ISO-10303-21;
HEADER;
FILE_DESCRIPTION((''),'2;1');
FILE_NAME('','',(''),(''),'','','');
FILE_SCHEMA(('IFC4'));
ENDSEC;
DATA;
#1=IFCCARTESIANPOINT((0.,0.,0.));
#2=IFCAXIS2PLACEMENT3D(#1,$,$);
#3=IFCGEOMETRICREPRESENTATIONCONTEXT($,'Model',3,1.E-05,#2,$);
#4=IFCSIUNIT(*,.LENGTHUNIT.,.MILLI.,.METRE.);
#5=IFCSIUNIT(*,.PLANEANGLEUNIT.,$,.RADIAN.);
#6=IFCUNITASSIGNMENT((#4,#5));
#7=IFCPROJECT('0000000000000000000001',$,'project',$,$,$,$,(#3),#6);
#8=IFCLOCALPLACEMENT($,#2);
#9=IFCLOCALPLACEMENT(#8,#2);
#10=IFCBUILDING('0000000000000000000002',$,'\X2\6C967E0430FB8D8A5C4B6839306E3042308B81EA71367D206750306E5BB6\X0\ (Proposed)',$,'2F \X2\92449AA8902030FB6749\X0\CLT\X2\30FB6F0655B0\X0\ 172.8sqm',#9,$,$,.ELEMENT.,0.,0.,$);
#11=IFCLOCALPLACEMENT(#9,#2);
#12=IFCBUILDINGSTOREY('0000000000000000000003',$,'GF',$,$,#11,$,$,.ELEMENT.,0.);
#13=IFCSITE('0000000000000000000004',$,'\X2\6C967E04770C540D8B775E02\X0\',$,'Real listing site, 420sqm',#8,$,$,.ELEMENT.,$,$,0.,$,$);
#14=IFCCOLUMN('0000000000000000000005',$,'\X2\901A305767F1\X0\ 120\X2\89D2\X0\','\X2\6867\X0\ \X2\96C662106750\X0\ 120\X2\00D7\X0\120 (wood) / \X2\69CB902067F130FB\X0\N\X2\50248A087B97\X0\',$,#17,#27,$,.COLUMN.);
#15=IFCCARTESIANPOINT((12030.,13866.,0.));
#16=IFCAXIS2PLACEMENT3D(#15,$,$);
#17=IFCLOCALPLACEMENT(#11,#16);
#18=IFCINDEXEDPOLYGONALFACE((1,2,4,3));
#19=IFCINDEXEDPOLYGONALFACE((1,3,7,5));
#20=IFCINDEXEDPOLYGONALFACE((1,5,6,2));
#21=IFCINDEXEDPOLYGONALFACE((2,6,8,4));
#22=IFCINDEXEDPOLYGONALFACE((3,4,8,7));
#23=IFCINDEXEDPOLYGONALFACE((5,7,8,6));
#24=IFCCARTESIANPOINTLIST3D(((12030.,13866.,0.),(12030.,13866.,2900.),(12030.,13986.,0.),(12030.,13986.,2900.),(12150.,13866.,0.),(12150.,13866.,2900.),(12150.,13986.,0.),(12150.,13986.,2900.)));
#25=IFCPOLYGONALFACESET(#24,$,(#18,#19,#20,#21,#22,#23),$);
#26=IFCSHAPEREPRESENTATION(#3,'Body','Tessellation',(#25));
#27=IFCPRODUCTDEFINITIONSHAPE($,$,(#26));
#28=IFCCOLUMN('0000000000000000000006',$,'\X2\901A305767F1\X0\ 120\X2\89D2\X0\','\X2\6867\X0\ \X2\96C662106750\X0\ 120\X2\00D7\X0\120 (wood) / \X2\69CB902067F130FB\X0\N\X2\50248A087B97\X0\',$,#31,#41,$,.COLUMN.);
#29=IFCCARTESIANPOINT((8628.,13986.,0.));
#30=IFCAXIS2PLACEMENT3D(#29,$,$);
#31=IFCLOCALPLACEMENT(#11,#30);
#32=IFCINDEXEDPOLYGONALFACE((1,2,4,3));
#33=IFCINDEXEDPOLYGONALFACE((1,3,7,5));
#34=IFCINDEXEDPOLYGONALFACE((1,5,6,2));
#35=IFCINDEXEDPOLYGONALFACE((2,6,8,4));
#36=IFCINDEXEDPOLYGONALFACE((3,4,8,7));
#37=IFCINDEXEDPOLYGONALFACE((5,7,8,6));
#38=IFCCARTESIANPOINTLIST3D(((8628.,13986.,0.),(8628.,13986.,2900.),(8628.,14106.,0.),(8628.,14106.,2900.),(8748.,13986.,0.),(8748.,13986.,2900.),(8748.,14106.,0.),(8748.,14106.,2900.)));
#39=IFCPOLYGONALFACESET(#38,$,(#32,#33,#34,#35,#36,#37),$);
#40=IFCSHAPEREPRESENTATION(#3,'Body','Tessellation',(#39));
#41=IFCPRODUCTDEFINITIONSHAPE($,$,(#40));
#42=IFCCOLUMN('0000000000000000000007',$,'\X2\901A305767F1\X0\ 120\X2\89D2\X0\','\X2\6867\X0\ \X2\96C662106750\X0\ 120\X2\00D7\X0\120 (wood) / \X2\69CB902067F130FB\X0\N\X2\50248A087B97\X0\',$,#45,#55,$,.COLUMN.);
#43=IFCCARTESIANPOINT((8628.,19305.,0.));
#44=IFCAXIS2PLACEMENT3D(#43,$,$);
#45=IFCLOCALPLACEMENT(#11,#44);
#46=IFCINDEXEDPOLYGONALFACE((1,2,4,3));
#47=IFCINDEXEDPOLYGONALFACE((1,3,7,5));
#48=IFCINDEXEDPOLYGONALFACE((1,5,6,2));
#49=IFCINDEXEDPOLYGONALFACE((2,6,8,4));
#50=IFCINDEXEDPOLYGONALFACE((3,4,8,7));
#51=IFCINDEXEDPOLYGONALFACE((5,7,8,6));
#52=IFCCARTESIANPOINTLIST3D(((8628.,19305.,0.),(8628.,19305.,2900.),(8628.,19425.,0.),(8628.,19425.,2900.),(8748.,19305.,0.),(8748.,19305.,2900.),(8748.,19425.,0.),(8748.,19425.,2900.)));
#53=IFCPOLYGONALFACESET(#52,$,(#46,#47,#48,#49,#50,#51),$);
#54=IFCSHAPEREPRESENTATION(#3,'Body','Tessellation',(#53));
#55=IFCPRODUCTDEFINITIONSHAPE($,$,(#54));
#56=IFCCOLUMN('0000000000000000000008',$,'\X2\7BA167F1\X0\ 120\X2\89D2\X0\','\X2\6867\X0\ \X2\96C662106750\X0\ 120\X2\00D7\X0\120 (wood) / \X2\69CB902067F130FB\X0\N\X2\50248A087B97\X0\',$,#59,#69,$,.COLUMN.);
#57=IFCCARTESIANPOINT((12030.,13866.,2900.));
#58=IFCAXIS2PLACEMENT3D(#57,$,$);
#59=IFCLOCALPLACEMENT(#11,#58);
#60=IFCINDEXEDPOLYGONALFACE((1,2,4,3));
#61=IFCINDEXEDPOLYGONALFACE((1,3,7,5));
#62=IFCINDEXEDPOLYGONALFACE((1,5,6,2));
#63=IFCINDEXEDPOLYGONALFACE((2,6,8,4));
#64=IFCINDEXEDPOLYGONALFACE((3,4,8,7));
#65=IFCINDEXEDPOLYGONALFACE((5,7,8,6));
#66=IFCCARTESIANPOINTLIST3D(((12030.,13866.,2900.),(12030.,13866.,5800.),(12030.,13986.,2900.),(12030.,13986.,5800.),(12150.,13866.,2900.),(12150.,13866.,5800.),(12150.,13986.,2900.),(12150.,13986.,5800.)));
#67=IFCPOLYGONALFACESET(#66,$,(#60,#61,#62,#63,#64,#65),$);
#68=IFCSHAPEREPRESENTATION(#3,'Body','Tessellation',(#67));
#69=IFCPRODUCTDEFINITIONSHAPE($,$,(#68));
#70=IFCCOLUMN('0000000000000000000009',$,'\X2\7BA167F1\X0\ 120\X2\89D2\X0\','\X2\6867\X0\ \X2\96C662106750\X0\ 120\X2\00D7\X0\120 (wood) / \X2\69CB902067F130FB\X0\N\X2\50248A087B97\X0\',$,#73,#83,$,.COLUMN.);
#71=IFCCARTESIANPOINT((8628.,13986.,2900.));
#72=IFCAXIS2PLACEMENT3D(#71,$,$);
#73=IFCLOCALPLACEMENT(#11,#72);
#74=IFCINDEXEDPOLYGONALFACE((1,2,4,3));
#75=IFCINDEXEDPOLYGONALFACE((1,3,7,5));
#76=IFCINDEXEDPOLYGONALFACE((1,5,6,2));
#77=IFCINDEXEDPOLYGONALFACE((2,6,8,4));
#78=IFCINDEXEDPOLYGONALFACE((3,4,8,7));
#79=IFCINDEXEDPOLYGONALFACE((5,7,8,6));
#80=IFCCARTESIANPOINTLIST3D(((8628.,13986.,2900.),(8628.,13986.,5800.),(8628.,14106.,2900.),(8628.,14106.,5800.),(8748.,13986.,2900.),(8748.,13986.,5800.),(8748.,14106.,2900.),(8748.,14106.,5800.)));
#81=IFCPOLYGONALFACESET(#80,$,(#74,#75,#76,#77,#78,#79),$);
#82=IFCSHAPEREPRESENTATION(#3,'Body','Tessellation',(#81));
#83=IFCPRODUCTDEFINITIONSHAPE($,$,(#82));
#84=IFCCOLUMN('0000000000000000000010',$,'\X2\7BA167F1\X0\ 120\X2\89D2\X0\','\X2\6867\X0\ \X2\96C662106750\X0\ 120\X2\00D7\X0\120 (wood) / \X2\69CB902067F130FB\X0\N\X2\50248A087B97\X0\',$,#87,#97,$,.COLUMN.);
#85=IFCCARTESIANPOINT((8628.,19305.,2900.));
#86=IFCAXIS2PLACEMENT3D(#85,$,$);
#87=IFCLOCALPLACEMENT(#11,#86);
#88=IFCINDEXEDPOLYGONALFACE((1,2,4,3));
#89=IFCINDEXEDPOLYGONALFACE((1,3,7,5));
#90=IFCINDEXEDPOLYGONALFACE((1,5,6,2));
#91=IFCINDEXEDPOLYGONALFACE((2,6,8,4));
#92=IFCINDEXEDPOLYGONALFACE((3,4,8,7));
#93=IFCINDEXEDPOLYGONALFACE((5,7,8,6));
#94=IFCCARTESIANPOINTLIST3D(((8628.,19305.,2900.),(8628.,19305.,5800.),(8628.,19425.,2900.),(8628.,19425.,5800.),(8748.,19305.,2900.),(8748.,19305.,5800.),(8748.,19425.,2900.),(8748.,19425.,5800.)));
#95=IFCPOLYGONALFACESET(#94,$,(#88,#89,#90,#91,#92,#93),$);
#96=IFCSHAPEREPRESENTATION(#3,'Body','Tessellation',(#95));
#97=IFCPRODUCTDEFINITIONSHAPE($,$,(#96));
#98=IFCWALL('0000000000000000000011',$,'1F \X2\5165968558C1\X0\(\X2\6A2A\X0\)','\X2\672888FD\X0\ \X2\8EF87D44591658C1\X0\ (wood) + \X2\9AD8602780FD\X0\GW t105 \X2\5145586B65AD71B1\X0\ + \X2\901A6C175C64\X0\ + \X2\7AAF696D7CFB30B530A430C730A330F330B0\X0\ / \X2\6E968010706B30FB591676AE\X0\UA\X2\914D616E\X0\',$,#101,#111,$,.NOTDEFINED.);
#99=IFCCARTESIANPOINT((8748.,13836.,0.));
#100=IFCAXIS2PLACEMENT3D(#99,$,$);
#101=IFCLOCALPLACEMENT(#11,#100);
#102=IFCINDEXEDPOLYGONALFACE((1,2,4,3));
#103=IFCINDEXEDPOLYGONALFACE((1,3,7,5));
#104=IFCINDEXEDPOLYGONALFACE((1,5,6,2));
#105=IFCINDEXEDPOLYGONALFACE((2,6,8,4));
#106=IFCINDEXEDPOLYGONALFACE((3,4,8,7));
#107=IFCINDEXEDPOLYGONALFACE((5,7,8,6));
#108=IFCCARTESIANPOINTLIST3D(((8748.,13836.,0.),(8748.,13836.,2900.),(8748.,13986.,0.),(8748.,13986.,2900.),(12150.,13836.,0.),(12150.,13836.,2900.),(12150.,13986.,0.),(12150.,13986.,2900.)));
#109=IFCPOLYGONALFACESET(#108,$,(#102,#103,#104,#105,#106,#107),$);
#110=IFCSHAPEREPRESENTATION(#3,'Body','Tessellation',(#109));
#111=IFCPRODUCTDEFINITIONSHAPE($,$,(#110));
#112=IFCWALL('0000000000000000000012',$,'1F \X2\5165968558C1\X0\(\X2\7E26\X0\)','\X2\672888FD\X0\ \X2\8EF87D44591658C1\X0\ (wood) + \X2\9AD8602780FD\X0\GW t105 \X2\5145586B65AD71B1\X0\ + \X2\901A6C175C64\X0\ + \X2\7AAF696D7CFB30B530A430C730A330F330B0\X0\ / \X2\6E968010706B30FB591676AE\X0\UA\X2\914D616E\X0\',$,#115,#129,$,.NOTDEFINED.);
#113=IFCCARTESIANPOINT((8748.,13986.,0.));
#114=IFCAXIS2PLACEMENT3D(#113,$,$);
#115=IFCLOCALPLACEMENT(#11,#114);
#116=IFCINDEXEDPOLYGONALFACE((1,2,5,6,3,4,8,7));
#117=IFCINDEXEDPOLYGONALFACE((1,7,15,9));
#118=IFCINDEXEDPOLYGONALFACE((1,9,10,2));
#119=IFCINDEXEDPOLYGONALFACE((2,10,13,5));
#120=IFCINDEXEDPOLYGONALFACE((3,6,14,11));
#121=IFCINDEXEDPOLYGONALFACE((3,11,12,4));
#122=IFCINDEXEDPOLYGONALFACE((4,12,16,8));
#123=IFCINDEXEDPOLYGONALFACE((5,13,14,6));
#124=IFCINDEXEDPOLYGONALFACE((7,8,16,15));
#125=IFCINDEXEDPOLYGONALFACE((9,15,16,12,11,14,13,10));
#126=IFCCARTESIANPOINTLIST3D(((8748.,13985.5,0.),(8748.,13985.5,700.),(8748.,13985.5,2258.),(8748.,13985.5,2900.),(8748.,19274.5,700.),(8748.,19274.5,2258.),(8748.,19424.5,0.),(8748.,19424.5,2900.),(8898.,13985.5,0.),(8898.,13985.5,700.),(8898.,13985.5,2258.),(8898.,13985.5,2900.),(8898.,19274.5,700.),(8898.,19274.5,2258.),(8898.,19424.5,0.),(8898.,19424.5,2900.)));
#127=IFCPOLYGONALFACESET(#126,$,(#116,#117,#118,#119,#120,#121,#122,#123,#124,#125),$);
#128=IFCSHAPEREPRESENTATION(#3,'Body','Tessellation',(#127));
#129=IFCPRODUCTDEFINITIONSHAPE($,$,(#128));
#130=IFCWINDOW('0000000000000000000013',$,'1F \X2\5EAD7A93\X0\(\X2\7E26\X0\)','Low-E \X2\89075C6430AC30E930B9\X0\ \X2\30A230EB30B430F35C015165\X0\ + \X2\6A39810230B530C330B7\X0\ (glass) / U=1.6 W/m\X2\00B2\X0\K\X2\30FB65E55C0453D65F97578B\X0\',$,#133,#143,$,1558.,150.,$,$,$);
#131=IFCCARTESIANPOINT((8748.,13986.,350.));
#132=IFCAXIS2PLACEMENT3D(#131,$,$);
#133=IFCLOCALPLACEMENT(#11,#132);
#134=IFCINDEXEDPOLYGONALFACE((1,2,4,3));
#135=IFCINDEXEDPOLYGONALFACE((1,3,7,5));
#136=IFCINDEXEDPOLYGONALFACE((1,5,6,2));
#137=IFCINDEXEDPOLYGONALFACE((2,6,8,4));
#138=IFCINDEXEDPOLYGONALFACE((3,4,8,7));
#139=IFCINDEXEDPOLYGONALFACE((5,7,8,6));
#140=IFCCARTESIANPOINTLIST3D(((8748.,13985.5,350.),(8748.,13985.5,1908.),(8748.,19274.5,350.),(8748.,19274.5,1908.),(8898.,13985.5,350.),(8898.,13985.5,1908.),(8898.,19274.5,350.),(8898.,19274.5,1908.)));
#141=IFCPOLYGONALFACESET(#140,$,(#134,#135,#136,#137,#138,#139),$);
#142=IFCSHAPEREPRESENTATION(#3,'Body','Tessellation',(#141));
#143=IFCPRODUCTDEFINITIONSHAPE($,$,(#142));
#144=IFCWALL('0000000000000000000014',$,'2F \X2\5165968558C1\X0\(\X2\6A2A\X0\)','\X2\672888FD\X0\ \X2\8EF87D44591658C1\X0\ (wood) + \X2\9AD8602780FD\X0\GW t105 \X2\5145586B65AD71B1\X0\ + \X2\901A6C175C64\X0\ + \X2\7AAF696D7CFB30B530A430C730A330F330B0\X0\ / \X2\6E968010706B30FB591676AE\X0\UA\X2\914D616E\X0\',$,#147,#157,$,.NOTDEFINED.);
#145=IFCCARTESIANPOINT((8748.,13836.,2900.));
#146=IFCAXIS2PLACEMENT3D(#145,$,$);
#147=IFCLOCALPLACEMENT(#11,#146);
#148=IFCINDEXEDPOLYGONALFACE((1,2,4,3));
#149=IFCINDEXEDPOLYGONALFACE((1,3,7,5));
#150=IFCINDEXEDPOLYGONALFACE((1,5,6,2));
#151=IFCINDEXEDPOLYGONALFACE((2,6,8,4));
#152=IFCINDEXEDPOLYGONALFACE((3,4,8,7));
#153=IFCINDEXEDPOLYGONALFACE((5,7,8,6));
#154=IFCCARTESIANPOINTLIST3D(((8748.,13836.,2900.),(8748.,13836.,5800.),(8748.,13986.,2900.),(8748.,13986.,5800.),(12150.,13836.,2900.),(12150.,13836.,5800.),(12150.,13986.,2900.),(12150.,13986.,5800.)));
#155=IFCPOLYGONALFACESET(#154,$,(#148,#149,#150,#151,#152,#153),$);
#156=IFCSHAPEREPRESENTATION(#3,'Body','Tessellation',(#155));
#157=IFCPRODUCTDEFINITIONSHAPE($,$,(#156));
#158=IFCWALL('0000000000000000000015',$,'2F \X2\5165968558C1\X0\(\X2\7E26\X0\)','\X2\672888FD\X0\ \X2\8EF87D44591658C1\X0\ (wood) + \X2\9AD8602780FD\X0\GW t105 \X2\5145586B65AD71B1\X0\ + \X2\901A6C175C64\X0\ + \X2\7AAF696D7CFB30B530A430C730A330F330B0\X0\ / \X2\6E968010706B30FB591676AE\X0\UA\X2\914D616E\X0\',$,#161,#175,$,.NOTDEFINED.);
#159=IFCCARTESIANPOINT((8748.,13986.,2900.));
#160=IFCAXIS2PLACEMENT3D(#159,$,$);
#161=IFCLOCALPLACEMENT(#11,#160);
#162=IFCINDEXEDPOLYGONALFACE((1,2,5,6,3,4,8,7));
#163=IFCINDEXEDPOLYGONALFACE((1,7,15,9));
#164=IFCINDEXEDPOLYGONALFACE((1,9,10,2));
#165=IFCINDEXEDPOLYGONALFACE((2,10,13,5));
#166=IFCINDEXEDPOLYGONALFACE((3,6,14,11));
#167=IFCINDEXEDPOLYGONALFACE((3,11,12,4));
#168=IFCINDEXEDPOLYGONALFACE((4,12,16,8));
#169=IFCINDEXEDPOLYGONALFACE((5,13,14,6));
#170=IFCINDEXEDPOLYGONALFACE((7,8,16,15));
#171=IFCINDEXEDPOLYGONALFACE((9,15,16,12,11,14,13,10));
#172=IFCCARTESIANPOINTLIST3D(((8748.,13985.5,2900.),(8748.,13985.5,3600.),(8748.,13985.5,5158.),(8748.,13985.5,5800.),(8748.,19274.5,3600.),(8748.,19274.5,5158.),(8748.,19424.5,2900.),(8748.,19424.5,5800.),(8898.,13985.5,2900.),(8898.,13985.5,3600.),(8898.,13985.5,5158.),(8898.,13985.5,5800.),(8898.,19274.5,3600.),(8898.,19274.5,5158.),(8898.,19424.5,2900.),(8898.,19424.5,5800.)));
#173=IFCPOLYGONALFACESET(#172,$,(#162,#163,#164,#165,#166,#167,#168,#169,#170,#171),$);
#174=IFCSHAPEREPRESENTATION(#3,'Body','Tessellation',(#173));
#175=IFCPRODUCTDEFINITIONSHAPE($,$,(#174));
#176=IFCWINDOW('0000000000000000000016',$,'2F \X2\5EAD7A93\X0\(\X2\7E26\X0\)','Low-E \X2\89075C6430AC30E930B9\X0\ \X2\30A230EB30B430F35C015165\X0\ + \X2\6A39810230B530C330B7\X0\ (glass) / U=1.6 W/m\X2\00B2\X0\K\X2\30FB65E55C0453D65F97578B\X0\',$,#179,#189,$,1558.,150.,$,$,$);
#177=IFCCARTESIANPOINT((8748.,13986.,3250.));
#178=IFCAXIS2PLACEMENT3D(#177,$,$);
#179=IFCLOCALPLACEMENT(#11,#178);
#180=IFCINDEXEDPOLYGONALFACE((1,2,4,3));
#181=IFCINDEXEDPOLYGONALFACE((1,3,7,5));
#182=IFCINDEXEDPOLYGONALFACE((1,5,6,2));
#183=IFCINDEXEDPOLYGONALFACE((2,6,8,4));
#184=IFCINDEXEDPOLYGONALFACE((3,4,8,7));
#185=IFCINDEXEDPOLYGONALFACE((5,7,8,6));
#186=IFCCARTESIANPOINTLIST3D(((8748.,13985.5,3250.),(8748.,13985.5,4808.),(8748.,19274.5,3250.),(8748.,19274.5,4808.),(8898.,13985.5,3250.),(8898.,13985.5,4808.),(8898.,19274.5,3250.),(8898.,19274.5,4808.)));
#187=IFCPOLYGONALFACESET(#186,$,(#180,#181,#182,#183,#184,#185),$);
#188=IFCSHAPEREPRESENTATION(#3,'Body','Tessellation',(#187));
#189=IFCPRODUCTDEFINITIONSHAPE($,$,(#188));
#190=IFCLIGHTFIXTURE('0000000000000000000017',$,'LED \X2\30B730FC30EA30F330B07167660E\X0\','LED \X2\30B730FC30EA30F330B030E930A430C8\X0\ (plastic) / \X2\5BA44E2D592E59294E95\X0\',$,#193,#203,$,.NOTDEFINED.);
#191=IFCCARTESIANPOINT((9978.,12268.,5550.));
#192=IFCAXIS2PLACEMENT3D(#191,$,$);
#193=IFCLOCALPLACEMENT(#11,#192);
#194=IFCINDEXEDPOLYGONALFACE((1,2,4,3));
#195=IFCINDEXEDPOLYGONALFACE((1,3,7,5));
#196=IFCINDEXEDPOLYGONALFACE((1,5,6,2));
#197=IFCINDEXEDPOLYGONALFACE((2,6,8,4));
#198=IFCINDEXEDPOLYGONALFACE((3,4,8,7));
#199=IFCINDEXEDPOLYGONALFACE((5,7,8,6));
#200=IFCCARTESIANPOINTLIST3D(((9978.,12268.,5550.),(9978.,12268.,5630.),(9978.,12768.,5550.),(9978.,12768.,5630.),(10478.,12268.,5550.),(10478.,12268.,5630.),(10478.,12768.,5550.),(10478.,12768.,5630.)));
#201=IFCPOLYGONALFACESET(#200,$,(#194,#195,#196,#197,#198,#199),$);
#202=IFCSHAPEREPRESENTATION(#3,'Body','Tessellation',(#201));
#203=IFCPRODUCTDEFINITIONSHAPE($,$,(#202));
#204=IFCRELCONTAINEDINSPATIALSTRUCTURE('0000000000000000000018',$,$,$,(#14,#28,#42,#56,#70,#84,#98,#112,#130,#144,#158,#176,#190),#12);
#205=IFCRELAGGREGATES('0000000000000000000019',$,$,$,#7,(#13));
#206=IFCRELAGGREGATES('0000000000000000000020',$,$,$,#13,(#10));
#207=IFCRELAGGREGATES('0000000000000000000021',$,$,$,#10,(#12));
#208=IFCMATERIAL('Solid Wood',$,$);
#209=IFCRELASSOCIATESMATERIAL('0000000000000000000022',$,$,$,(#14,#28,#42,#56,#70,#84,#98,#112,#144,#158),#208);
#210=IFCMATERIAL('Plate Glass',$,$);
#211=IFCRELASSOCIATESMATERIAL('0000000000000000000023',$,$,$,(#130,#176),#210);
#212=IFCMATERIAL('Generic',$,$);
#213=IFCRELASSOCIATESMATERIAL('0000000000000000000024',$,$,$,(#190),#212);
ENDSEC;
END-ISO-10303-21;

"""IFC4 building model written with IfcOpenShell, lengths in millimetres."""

from ifc_helpers import new_model, si_unit, frame, frame_2d, origin, place, context, project, spatial, rectangle, extrude, material, element, fill, save


model = new_model("IFC4")

# Units and contexts
model_context = context("Model", 3, precision=1e-05, world=origin())
ifc_project = project(units=[si_unit("LENGTHUNIT", "METRE", prefix="MILLI"), si_unit("PLANEANGLEUNIT", "RADIAN")], contexts=[model_context])

# Site, building, storey
site_placement = place(None, origin())
site = spatial("IfcSite", under=ifc_project, at=site_placement, Name="沖縄県名護市", ObjectType="Real listing site, 420sqm", CompositionType="ELEMENT", RefElevation=0.0)
building_placement = place(site_placement, origin())
building = spatial("IfcBuilding", under=site, at=building_placement, Name="沖縄・越屋根のある自然素材の家 (Proposed)", ObjectType="2F 鉄骨造・杉CLT・漆喰 172.8sqm", CompositionType="ELEMENT", ElevationOfRefHeight=0.0, ElevationOfTerrain=0.0)
storey_placement = place(building_placement, origin())
storey = spatial("IfcBuildingStorey", under=building, at=storey_placement, Name="GF", CompositionType="ELEMENT", Elevation=0.0)

# Columns
ifc_material_1 = material(Name="Solid Wood")
column_1_placement = place(storey_placement, frame((12030.0, 13866.0, 0.0)))
element("IfcColumn", 1, at=column_1_placement, inside=storey, material=ifc_material_1, Name="通し柱 120角", Description="桧 集成材 120×120 (wood) / 構造柱・N値計算", PredefinedType="COLUMN", context=model_context, shape_type="SweptSolid", body=[
    extrude(rectangle(XDim=120.0, YDim=120.0, at=frame_2d((60.0, 60.0))), frame((12030.0, 13866.0, 0.0)), (0.0, 0.0, 1.0), 2900.0),
])
column_2_placement = place(storey_placement, frame((8628.0, 13986.0, 0.0)))
element("IfcColumn", 2, at=column_2_placement, inside=storey, material=ifc_material_1, Name="通し柱 120角", Description="桧 集成材 120×120 (wood) / 構造柱・N値計算", PredefinedType="COLUMN", context=model_context, shape_type="SweptSolid", body=[
    extrude(rectangle(XDim=120.0, YDim=120.0, at=frame_2d((60.0, 60.0))), frame((8628.0, 13986.0, 0.0)), (0.0, 0.0, 1.0), 2900.0),
])
column_3_placement = place(storey_placement, frame((8628.0, 19305.0, 0.0)))
element("IfcColumn", 3, at=column_3_placement, inside=storey, material=ifc_material_1, Name="通し柱 120角", Description="桧 集成材 120×120 (wood) / 構造柱・N値計算", PredefinedType="COLUMN", context=model_context, shape_type="SweptSolid", body=[
    extrude(rectangle(XDim=120.0, YDim=120.0, at=frame_2d((60.0, 60.0))), frame((8628.0, 19305.0, 0.0)), (0.0, 0.0, 1.0), 2900.0),
])
column_4_placement = place(storey_placement, frame((12030.0, 13866.0, 2900.0)))
element("IfcColumn", 4, at=column_4_placement, inside=storey, material=ifc_material_1, Name="管柱 120角", Description="桧 集成材 120×120 (wood) / 構造柱・N値計算", PredefinedType="COLUMN", context=model_context, shape_type="SweptSolid", body=[
    extrude(rectangle(XDim=120.0, YDim=120.0, at=frame_2d((60.0, 60.0))), frame((12030.0, 13866.0, 2900.0)), (0.0, 0.0, 1.0), 2900.0),
])
column_5_placement = place(storey_placement, frame((8628.0, 13986.0, 2900.0)))
element("IfcColumn", 5, at=column_5_placement, inside=storey, material=ifc_material_1, Name="管柱 120角", Description="桧 集成材 120×120 (wood) / 構造柱・N値計算", PredefinedType="COLUMN", context=model_context, shape_type="SweptSolid", body=[
    extrude(rectangle(XDim=120.0, YDim=120.0, at=frame_2d((60.0, 60.0))), frame((8628.0, 13986.0, 2900.0)), (0.0, 0.0, 1.0), 2900.0),
])
column_6_placement = place(storey_placement, frame((8628.0, 19305.0, 2900.0)))
element("IfcColumn", 6, at=column_6_placement, inside=storey, material=ifc_material_1, Name="管柱 120角", Description="桧 集成材 120×120 (wood) / 構造柱・N値計算", PredefinedType="COLUMN", context=model_context, shape_type="SweptSolid", body=[
    extrude(rectangle(XDim=120.0, YDim=120.0, at=frame_2d((60.0, 60.0))), frame((8628.0, 19305.0, 2900.0)), (0.0, 0.0, 1.0), 2900.0),
])

# Wall
wall_1_placement = place(storey_placement, frame((8748.0, 13836.0, 0.0)))
element("IfcWall", 7, at=wall_1_placement, inside=storey, material=ifc_material_1, Name="1F 入隅壁(横)", Description="木製 軸組外壁 (wood) + 高性能GW t105 充填断熱 + 通気層 + 窯業系サイディング / 準耐火・外皮UA配慮", PredefinedType="NOTDEFINED", context=model_context, shape_type="SweptSolid", body=[
    extrude(rectangle(XDim=3402.0, YDim=150.0, at=frame_2d((1701.0, 75.0))), frame((8748.0, 13836.0, 0.0)), (0.0, 0.0, 1.0), 2900.0),
])

# Wall, opening, window
wall_2_placement = place(storey_placement, frame((8748.0, 13986.0, 0.0)))
wall_2 = element("IfcWall", 8, at=wall_2_placement, inside=storey, material=ifc_material_1, Name="1F 入隅壁(縦)", Description="木製 軸組外壁 (wood) + 高性能GW t105 充填断熱 + 通気層 + 窯業系サイディング / 準耐火・外皮UA配慮", PredefinedType="NOTDEFINED", context=model_context, shape_type="SweptSolid", body=[
    extrude(rectangle(XDim=150.0, YDim=5439.0, at=frame_2d((75.0, 2719.0))), frame((8748.0, 13986.0, 0.0)), (0.0, 0.0, 1.0), 2900.0),
])
opening_1_placement = place(storey_placement, frame((8748.0, 13986.0, 350.0)))
opening_1 = element("IfcOpeningElement", 9, at=opening_1_placement, cuts=wall_2, PredefinedType="NOTDEFINED", context=model_context, shape_type="SweptSolid", body=[
    extrude(rectangle(XDim=150.0, YDim=5289.0, at=frame_2d((75.0, 2644.0))), frame((8748.0, 13986.0, 350.0)), (0.0, 0.0, 1.0), 1558.0),
])
ifc_material_2 = material(Name="Plate Glass")
window_1_placement = place(storey_placement, frame((8748.0, 13986.0, 350.0)))
window_1 = element("IfcWindow", 10, at=window_1_placement, inside=storey, material=ifc_material_2, Name="1F 庭窓(縦)", Description="Low-E 複層ガラス アルゴン封入 + 樹脂サッシ (glass) / U=1.6 W/m²K・日射取得型", OverallHeight=1558.0, OverallWidth=150.0, context=model_context, shape_type="SweptSolid", body=[
    extrude(rectangle(XDim=150.0, YDim=5289.0, at=frame_2d((75.0, 2644.0))), frame((8748.0, 13986.0, 350.0)), (0.0, 0.0, 1.0), 1558.0),
])
fill(opening_1, window_1)

# Wall
wall_3_placement = place(storey_placement, frame((8748.0, 13836.0, 2900.0)))
element("IfcWall", 11, at=wall_3_placement, inside=storey, material=ifc_material_1, Name="2F 入隅壁(横)", Description="木製 軸組外壁 (wood) + 高性能GW t105 充填断熱 + 通気層 + 窯業系サイディング / 準耐火・外皮UA配慮", PredefinedType="NOTDEFINED", context=model_context, shape_type="SweptSolid", body=[
    extrude(rectangle(XDim=3402.0, YDim=150.0, at=frame_2d((1701.0, 75.0))), frame((8748.0, 13836.0, 2900.0)), (0.0, 0.0, 1.0), 2900.0),
])

# Wall, opening, window
wall_4_placement = place(storey_placement, frame((8748.0, 13986.0, 2900.0)))
wall_4 = element("IfcWall", 12, at=wall_4_placement, inside=storey, material=ifc_material_1, Name="2F 入隅壁(縦)", Description="木製 軸組外壁 (wood) + 高性能GW t105 充填断熱 + 通気層 + 窯業系サイディング / 準耐火・外皮UA配慮", PredefinedType="NOTDEFINED", context=model_context, shape_type="SweptSolid", body=[
    extrude(rectangle(XDim=150.0, YDim=5439.0, at=frame_2d((75.0, 2719.0))), frame((8748.0, 13986.0, 2900.0)), (0.0, 0.0, 1.0), 2900.0),
])
opening_2_placement = place(storey_placement, frame((8748.0, 13986.0, 3250.0)))
opening_2 = element("IfcOpeningElement", 13, at=opening_2_placement, cuts=wall_4, PredefinedType="NOTDEFINED", context=model_context, shape_type="SweptSolid", body=[
    extrude(rectangle(XDim=150.0, YDim=5289.0, at=frame_2d((75.0, 2644.0))), frame((8748.0, 13986.0, 3250.0)), (0.0, 0.0, 1.0), 1558.0),
])
window_2_placement = place(storey_placement, frame((8748.0, 13986.0, 3250.0)))
window_2 = element("IfcWindow", 14, at=window_2_placement, inside=storey, material=ifc_material_2, Name="2F 庭窓(縦)", Description="Low-E 複層ガラス アルゴン封入 + 樹脂サッシ (glass) / U=1.6 W/m²K・日射取得型", OverallHeight=1558.0, OverallWidth=150.0, context=model_context, shape_type="SweptSolid", body=[
    extrude(rectangle(XDim=150.0, YDim=5289.0, at=frame_2d((75.0, 2644.0))), frame((8748.0, 13986.0, 3250.0)), (0.0, 0.0, 1.0), 1558.0),
])
fill(opening_2, window_2)

# Light fixture
ifc_material_3 = material(Name="Generic")
light_fixture_placement = place(storey_placement, frame((9978.0, 12268.0, 5550.0)))
element("IfcLightFixture", 15, at=light_fixture_placement, inside=storey, material=ifc_material_3, Name="LED シーリング照明", Description="LED シーリングライト (plastic) / 室中央天井", PredefinedType="NOTDEFINED", context=model_context, shape_type="SweptSolid", body=[
    extrude(rectangle(XDim=500.0, YDim=500.0, at=frame_2d((250.0, 250.0))), frame((9978.0, 12268.0, 5550.0)), (0.0, 0.0, 1.0), 80.0),
])

save(model, "model.ifc")
